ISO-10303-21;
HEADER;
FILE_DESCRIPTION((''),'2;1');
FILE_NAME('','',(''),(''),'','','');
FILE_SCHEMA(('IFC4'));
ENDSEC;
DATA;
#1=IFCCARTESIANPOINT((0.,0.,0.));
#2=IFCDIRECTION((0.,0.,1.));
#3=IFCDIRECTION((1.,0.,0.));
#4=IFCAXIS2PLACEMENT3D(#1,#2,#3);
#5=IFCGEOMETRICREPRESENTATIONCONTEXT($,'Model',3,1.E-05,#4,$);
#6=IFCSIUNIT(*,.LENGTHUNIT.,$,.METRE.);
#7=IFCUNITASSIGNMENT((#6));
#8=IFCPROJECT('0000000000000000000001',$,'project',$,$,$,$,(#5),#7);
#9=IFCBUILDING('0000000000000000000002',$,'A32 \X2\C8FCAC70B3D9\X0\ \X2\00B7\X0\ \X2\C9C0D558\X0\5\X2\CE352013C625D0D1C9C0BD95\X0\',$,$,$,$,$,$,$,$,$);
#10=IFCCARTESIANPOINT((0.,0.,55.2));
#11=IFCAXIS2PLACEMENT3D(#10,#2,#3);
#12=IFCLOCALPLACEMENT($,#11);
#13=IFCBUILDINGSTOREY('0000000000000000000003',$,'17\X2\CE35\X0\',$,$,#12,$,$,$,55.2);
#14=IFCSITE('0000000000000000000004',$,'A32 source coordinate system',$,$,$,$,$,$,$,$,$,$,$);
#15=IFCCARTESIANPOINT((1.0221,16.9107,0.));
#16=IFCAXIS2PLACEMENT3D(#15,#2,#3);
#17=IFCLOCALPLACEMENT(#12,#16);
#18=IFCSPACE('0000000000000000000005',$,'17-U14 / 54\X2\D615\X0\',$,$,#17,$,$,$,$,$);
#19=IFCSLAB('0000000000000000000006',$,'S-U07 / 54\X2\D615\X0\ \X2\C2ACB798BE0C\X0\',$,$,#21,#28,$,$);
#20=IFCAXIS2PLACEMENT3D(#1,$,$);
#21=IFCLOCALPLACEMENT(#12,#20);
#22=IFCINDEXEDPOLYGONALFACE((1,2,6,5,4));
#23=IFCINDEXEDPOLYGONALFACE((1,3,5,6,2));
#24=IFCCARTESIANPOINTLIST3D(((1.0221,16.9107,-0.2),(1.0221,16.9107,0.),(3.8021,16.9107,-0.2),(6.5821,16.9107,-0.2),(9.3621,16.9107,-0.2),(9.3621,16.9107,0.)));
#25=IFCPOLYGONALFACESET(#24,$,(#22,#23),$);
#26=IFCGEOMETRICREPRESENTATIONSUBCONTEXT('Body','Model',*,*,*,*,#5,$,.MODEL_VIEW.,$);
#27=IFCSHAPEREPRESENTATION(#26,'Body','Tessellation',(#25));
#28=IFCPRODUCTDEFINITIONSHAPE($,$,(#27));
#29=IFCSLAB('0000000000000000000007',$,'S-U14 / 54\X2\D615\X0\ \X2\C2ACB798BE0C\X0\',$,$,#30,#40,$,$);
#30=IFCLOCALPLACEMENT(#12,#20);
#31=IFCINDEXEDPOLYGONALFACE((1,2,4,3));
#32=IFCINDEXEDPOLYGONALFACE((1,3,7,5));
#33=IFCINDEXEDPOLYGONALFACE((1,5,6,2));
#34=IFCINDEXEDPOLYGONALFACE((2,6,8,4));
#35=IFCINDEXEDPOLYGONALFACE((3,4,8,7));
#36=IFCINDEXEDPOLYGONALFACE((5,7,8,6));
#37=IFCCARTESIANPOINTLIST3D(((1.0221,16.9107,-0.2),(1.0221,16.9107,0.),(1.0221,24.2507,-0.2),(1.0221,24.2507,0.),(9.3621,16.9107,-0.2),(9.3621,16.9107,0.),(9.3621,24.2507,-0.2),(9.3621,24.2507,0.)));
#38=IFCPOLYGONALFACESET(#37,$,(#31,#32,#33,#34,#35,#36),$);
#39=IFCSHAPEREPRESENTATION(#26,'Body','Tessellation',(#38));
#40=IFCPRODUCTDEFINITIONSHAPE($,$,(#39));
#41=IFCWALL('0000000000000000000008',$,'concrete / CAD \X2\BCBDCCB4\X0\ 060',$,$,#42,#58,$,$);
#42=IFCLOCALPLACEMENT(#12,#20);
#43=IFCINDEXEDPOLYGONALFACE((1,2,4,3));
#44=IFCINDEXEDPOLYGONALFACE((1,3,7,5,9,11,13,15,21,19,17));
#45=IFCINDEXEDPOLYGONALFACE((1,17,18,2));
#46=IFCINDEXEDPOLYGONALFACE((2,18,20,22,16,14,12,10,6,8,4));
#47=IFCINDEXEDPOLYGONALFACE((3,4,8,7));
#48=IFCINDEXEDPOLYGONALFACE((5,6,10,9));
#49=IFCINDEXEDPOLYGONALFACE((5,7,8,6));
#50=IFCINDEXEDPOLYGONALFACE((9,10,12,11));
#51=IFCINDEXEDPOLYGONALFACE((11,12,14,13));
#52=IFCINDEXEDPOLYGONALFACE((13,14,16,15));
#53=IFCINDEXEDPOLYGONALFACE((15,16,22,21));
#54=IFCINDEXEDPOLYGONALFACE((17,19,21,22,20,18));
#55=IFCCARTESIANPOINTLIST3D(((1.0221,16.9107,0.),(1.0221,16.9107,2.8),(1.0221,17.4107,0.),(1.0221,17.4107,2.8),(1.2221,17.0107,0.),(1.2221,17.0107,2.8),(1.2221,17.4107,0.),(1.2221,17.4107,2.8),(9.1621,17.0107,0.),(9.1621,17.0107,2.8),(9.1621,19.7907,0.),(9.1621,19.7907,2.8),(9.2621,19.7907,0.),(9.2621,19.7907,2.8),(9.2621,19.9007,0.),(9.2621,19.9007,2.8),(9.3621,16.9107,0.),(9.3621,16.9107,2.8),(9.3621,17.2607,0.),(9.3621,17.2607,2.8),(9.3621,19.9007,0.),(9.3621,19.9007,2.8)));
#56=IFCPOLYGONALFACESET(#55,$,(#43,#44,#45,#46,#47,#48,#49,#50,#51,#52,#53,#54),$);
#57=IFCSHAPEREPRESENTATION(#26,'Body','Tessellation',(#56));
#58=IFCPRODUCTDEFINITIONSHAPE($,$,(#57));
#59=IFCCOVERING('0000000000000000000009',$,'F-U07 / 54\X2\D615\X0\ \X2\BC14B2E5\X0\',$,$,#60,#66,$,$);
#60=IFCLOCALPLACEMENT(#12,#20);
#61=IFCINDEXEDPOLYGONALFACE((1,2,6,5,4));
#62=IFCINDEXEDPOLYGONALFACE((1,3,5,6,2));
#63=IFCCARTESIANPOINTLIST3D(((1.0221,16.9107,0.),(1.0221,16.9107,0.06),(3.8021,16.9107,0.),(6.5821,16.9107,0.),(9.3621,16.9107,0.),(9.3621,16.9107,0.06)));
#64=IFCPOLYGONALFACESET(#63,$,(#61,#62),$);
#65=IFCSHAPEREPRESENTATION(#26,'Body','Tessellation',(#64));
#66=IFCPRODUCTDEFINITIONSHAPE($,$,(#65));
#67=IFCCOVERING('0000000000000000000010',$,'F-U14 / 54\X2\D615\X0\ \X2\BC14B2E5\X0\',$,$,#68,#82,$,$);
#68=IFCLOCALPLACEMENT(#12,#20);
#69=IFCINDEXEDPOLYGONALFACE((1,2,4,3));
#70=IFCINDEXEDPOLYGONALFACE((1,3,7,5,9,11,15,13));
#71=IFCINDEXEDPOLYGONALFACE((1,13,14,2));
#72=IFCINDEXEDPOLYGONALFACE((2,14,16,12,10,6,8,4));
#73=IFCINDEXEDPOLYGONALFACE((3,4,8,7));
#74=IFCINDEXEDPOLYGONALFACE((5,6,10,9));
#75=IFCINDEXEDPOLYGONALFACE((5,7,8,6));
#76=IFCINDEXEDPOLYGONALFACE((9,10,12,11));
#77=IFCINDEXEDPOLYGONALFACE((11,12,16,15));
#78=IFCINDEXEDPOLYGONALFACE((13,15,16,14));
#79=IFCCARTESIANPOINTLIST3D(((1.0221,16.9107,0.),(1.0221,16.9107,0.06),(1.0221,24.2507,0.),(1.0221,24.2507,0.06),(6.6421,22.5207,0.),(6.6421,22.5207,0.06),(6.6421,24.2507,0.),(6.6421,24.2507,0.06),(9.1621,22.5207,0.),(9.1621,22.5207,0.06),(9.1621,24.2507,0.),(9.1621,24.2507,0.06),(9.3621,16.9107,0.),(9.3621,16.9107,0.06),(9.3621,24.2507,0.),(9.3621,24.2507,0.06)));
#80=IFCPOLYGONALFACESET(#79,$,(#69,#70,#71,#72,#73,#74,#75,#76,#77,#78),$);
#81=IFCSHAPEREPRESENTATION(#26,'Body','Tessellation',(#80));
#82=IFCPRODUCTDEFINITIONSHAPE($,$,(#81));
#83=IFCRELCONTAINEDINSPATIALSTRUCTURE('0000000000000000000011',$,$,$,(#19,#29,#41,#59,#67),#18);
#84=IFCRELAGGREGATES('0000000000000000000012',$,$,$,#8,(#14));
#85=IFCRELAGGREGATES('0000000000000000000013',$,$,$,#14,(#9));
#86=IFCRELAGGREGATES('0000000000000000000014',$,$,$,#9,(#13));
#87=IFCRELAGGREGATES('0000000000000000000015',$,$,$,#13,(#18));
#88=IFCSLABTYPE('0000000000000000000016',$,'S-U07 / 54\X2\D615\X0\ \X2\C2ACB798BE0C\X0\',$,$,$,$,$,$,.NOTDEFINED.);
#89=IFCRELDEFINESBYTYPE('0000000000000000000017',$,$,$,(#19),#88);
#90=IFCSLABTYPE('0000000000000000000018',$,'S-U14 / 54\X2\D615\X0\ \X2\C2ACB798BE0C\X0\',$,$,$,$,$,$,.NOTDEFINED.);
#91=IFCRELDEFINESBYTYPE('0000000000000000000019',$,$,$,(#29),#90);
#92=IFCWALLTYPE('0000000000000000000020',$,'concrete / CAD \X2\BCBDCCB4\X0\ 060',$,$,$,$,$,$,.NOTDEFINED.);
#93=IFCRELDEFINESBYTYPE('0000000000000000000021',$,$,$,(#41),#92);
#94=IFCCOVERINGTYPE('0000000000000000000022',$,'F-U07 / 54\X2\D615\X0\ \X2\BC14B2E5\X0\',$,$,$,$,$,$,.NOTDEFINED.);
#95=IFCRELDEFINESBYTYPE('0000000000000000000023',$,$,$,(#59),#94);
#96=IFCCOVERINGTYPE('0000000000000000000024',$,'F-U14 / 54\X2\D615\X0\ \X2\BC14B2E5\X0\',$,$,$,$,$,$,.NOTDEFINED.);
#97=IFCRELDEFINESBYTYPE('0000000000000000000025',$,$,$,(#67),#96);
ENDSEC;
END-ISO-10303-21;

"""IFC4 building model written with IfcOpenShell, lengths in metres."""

from ifc_helpers import new_model, si_unit, frame, origin, origin_with_axes, place, context, subcontext, project, spatial, polyline, outline, extrude, source, transform, mapped, type_object, type_shapes, element, save


model = new_model("IFC4")

# Units and contexts
model_context = context("Model", 3, precision=1e-05, world=origin_with_axes())
body_context = subcontext(model_context, "Body", "Model", "MODEL_VIEW")
ifc_project = project(units=[si_unit("LENGTHUNIT", "METRE")], contexts=[model_context])

# Site, building, storey, space
storey_placement = place(None, frame((0.0, 0.0, 55.2), z_axis=(0.0, 0.0, 1.0), x_axis=(1.0, 0.0, 0.0)))
space_1_placement = place(storey_placement, frame((1.0221, 16.9107, 0.0), z_axis=(0.0, 0.0, 1.0), x_axis=(1.0, 0.0, 0.0)))
site = spatial("IfcSite", under=ifc_project, Name="A32 source coordinate system")
building = spatial("IfcBuilding", under=site, Name="A32 주거동 · 지하5층–옥탑지붕")
storey = spatial("IfcBuildingStorey", under=building, at=storey_placement, Name="17층", Elevation=55.2)
space_1 = spatial("IfcSpace", under=storey, at=space_1_placement, Name="17-U14 / 54형")

# Slabs
slab_type_1 = type_object("IfcSlabType", Name="S-U07 / 54형 슬래브", PredefinedType="NOTDEFINED")
shared_shape_1 = source(origin(), body_context, "Body", "SweptSolid", [
    extrude(outline(polyline([(0.0, 0.0), (0.0, 0.0), (8.34, 0.0), (8.34, 0.0), (0.0, 0.0)])), frame((0.0, 0.0, -0.2)), (0.0, 0.0, 1.0), 0.2),
])
type_shapes(slab_type_1, [shared_shape_1])
slab_1_placement = place(space_1_placement, origin_with_axes())
element("IfcSlab", 1, at=slab_1_placement, inside=space_1, type_object=slab_type_1, Name="S-U07 / 54형 슬래브", context=body_context, shape_type="MappedRepresentation", body=[
    mapped(shared_shape_1, transform((0.0, 0.0, 0.0), scale=1.0)),
])
slab_type_2 = type_object("IfcSlabType", Name="S-U14 / 54형 슬래브", PredefinedType="NOTDEFINED")
shared_shape_2 = source(origin(), body_context, "Body", "SweptSolid", [
    extrude(outline(polyline([(0.0, 0.0), (0.0, 7.34), (8.34, 7.34), (8.34, 0.0), (0.0, 0.0)])), frame((0.0, 0.0, -0.2)), (0.0, 0.0, 1.0), 0.2),
])
type_shapes(slab_type_2, [shared_shape_2])
slab_2_placement = place(space_1_placement, origin_with_axes())
element("IfcSlab", 2, at=slab_2_placement, inside=space_1, type_object=slab_type_2, Name="S-U14 / 54형 슬래브", context=body_context, shape_type="MappedRepresentation", body=[
    mapped(shared_shape_2, transform((0.0, 0.0, 0.0), scale=1.0)),
])

# Wall
wall_type_1 = type_object("IfcWallType", Name="concrete / CAD 벽체 060", PredefinedType="NOTDEFINED")
shared_shape_3 = source(origin(), body_context, "Body", "SweptSolid", [
    extrude(outline(polyline([(0.2, 0.5), (0.2, 0.1), (8.14, 0.1), (8.14, 2.88), (8.24, 2.88), (8.24, 2.99), (8.34, 2.99), (8.34, 0.35), (8.34, 0.35), (8.34, 0.0), (0.0, 0.0), (0.0, 0.5), (0.2, 0.5)])), origin(), (0.0, 0.0, 1.0), 2.8),
])
type_shapes(wall_type_1, [shared_shape_3])
wall_1_placement = place(space_1_placement, origin_with_axes())
element("IfcWall", 3, at=wall_1_placement, inside=space_1, type_object=wall_type_1, Name="concrete / CAD 벽체 060", context=body_context, shape_type="MappedRepresentation", body=[
    mapped(shared_shape_3, transform((0.0, 0.0, 0.0), scale=1.0)),
])

# Coverings
covering_type_1 = type_object("IfcCoveringType", Name="F-U07 / 54형 바닥", PredefinedType="NOTDEFINED")
shared_shape_4 = source(origin(), body_context, "Body", "SweptSolid", [
    extrude(outline(polyline([(0.0, 0.0), (0.0, 0.0), (8.34, 0.0), (8.34, 0.0), (0.0, 0.0)])), origin(), (0.0, 0.0, 1.0), 0.06),
])
type_shapes(covering_type_1, [shared_shape_4])
covering_1_placement = place(space_1_placement, origin_with_axes())
element("IfcCovering", 4, at=covering_1_placement, inside=space_1, type_object=covering_type_1, Name="F-U07 / 54형 바닥", context=body_context, shape_type="MappedRepresentation", body=[
    mapped(shared_shape_4, transform((0.0, 0.0, 0.0), scale=1.0)),
])
covering_type_2 = type_object("IfcCoveringType", Name="F-U14 / 54형 바닥", PredefinedType="NOTDEFINED")
shared_shape_5 = source(origin(), body_context, "Body", "SweptSolid", [
    extrude(outline(polyline([(8.14, 7.34), (8.34, 7.34), (8.34, 0.0), (0.0, 0.0), (0.0, 7.34), (5.62, 7.34), (5.62, 5.61), (8.14, 5.61), (8.14, 7.34)])), origin(), (0.0, 0.0, 1.0), 0.06),
])
type_shapes(covering_type_2, [shared_shape_5])
covering_2_placement = place(space_1_placement, origin_with_axes())
element("IfcCovering", 5, at=covering_2_placement, inside=space_1, type_object=covering_type_2, Name="F-U14 / 54형 바닥", context=body_context, shape_type="MappedRepresentation", body=[
    mapped(shared_shape_5, transform((0.0, 0.0, 0.0), scale=1.0)),
])

save(model, "model.ifc")
